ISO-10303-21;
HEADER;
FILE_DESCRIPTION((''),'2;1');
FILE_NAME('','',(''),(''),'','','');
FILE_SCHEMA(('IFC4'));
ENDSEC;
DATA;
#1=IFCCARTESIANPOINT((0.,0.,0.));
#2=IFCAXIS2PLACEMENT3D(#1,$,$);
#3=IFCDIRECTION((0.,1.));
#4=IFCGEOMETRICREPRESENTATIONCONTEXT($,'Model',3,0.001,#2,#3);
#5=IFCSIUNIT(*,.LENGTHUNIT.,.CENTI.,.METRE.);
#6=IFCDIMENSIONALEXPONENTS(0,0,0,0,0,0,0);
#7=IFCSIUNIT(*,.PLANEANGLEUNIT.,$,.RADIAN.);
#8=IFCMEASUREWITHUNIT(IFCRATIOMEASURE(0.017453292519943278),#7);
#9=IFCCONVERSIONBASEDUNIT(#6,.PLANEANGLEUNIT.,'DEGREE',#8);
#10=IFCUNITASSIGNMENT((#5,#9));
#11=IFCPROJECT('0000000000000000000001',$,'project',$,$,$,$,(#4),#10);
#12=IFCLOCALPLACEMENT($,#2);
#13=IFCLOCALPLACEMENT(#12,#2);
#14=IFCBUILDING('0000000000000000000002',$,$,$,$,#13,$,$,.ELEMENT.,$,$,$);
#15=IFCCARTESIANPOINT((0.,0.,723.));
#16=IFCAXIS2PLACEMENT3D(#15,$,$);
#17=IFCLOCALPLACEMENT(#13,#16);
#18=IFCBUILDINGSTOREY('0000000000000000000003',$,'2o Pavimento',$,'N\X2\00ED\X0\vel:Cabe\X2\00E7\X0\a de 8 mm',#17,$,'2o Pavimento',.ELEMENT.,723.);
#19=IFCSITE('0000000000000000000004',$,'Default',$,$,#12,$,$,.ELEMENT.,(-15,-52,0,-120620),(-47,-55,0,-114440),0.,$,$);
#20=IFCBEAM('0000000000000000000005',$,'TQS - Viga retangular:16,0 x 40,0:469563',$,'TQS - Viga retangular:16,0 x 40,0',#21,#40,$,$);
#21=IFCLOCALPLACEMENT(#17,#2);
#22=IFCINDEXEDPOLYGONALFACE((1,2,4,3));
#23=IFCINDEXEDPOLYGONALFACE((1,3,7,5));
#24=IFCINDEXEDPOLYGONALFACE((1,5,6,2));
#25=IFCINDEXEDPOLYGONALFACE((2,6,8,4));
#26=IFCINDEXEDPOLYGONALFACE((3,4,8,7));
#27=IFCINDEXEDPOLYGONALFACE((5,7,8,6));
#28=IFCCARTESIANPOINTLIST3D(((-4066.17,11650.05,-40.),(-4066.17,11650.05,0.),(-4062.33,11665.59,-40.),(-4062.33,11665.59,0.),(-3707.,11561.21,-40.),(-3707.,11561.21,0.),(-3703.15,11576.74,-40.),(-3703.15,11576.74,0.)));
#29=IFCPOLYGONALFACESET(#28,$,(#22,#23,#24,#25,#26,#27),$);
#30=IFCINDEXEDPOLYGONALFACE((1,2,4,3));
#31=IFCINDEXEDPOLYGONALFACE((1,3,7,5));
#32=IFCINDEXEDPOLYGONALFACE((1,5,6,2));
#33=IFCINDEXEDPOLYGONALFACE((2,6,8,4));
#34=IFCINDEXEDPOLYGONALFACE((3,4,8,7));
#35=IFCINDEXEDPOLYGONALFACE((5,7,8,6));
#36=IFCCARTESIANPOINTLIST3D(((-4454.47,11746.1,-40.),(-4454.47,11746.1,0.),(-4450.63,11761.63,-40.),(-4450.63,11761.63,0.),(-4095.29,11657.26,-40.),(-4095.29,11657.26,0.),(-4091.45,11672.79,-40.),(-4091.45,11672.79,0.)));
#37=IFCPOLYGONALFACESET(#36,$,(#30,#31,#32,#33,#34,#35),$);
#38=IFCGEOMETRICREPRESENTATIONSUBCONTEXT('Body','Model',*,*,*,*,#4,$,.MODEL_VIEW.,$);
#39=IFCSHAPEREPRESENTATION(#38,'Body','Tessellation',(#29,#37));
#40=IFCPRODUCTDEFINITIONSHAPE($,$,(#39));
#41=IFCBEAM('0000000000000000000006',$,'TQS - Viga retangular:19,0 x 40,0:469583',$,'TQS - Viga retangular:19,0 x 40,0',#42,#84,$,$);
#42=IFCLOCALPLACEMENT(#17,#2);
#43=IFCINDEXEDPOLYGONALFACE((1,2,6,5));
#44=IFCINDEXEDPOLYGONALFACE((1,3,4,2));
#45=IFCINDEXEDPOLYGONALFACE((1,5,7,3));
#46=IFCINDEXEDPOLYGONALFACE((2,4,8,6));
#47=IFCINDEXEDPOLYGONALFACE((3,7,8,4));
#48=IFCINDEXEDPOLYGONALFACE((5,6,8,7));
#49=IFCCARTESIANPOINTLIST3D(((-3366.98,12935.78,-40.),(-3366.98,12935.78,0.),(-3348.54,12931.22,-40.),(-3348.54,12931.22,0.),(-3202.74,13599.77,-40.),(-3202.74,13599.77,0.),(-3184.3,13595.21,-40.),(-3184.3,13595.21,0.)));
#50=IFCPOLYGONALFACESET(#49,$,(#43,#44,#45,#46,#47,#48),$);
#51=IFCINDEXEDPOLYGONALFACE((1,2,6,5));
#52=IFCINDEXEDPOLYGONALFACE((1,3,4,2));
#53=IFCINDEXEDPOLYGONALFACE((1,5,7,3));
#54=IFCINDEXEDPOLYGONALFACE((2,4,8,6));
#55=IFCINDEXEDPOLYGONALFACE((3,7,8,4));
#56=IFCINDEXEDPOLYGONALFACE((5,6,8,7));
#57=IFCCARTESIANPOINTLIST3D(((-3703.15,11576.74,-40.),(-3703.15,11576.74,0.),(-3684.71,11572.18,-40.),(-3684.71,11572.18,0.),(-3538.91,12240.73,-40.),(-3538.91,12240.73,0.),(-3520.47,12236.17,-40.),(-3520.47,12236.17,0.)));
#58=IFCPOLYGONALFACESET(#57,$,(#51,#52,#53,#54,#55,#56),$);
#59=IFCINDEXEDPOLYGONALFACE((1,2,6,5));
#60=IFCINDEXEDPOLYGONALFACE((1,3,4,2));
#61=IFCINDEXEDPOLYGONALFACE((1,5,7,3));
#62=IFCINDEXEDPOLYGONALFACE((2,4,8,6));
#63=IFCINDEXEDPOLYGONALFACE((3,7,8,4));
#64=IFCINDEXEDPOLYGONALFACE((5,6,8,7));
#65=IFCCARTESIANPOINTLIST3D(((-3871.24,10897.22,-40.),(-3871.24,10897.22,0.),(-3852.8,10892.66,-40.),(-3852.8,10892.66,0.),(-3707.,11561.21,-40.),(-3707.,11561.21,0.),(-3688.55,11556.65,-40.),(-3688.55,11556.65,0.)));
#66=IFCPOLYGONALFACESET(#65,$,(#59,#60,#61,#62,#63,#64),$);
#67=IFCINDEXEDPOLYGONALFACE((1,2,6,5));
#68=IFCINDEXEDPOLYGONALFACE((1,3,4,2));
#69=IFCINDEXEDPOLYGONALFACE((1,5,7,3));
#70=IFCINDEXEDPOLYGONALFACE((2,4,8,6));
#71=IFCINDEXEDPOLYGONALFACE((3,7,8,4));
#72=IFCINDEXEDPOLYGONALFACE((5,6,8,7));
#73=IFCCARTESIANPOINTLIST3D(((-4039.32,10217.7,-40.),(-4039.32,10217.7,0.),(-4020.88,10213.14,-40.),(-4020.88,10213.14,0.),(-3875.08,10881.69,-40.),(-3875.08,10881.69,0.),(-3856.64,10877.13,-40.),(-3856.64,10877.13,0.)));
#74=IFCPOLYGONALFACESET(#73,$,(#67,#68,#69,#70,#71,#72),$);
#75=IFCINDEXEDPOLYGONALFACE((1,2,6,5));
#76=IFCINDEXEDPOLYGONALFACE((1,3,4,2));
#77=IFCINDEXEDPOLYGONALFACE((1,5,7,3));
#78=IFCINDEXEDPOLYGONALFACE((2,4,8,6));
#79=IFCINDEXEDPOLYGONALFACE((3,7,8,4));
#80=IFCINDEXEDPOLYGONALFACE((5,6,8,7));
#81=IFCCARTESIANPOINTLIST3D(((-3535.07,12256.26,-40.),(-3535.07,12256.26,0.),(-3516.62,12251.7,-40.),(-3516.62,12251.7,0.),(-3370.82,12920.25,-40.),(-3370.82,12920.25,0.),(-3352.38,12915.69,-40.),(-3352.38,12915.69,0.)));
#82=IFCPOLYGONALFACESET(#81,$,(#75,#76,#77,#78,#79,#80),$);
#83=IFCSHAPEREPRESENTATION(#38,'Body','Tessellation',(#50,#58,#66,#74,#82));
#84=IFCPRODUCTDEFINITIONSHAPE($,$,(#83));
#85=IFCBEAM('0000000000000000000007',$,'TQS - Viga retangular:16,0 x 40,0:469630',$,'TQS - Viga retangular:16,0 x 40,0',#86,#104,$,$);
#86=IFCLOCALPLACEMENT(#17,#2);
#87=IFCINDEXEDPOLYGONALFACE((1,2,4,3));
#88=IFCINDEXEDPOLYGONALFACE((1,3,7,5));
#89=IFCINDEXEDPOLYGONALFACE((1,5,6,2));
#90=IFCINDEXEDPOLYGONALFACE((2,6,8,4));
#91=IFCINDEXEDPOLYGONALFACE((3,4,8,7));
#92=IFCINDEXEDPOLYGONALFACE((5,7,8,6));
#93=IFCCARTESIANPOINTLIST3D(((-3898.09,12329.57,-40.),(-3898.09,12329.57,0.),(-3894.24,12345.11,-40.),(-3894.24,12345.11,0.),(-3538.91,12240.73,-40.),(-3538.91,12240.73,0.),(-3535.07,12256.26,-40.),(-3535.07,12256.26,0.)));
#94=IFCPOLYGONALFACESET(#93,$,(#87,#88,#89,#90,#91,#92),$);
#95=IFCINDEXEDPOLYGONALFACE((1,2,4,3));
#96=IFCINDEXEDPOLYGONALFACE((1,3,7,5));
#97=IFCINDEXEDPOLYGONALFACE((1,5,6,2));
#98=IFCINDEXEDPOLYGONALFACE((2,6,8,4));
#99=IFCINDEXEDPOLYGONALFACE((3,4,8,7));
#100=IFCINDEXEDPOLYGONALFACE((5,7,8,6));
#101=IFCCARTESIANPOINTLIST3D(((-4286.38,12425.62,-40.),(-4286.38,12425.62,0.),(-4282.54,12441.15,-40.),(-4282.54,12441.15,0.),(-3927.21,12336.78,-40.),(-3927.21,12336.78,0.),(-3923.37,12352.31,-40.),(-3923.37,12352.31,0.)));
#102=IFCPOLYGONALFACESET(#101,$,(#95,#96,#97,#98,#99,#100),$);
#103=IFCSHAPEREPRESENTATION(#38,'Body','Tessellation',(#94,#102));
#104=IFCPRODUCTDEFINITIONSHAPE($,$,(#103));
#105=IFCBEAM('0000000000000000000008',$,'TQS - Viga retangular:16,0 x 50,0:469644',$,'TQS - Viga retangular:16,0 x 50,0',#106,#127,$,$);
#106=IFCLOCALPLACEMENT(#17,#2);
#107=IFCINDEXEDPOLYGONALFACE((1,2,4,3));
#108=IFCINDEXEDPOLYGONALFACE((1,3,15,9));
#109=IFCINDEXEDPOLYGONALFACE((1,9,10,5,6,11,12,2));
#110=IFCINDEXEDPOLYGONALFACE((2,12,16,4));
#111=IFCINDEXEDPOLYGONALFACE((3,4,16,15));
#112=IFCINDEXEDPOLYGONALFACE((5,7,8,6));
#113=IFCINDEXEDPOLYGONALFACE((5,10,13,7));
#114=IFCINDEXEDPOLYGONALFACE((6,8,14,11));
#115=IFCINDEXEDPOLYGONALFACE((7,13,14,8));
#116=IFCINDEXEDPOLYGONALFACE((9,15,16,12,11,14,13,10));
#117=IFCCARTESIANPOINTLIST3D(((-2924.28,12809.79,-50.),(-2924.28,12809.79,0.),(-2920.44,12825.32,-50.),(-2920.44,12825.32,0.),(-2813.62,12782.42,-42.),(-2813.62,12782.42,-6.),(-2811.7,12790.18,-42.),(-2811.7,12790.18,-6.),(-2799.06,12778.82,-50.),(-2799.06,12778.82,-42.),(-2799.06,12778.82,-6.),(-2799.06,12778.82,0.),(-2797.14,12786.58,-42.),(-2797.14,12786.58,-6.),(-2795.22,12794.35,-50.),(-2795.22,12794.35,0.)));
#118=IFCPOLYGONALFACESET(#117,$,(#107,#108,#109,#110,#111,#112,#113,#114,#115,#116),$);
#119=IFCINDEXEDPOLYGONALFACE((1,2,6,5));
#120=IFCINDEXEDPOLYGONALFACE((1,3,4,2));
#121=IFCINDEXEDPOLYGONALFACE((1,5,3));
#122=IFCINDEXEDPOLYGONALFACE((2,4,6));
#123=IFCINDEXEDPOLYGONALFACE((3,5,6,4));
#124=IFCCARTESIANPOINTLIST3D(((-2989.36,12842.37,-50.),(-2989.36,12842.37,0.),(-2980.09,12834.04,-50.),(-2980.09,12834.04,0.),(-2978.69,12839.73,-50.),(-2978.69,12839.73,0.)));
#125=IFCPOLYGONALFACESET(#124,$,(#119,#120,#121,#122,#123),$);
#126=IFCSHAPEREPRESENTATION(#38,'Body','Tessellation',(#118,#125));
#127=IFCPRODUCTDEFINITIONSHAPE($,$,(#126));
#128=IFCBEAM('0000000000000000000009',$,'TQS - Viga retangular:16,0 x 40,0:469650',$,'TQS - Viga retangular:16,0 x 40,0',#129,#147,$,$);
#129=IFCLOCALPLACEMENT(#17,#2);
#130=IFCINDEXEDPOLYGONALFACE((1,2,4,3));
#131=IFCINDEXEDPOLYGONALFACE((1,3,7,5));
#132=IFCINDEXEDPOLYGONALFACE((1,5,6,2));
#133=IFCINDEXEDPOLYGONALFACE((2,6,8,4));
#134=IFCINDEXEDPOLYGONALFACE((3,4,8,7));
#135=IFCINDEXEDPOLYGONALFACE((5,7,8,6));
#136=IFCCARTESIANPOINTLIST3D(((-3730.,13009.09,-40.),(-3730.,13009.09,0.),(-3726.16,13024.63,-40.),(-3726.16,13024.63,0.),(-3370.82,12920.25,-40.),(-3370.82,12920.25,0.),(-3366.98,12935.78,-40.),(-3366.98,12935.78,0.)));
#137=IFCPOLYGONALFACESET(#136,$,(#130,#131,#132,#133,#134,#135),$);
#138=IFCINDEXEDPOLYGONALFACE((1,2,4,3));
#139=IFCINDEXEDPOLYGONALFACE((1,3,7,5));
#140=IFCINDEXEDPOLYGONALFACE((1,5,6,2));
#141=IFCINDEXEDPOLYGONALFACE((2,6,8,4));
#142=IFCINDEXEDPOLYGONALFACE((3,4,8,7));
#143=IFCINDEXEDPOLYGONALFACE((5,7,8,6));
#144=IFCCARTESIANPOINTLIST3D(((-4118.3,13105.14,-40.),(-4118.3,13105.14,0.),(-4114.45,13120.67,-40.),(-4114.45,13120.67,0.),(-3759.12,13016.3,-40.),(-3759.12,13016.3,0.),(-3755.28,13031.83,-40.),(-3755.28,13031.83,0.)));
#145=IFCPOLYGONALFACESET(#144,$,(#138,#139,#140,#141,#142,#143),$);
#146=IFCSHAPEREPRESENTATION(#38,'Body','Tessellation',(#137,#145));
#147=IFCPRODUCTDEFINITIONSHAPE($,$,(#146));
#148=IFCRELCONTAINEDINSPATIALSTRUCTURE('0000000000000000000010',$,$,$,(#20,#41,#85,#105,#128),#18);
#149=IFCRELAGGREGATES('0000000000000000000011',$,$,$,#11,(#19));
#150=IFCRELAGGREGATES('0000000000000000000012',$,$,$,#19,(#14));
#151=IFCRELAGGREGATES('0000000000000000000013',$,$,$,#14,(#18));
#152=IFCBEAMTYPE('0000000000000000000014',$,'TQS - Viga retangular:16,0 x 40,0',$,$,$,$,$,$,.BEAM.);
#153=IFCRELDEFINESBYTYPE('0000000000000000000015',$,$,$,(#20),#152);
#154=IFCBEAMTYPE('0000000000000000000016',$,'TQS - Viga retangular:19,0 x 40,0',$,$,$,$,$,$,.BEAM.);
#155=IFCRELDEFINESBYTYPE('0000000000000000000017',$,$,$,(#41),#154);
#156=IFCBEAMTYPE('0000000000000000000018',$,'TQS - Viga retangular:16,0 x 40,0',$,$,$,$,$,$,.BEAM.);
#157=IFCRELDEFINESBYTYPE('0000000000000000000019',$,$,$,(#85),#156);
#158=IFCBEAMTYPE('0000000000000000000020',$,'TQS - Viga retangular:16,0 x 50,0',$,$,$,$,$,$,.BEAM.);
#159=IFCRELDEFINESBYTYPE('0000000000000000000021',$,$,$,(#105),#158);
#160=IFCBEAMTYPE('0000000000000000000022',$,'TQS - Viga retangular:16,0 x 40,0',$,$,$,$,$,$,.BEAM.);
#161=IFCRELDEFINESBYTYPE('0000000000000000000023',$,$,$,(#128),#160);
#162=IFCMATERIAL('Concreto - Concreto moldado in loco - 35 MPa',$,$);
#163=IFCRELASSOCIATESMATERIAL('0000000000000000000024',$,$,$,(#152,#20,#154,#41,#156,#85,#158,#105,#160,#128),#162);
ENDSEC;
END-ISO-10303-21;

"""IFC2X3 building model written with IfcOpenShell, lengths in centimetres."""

from ifc_helpers import new_model, entity, si_unit, converted_unit, direction, frame, frame_2d, origin, origin_2d_with_axis, place, context, subcontext, project, spatial, polyline, rectangle, extrude, boolean, clip, halfspace, bounded_halfspace, source, transform, mapped, material, type_object, type_shapes, element, save


model = new_model("IFC2X3")

# Units and contexts
model_context = context("Model", 3, precision=0.001, world=origin(), true_north=direction((0.0, 1.0)))
body_context = subcontext(model_context, "Body", "Model", "MODEL_VIEW")
ifc_project = project(units=[si_unit("LENGTHUNIT", "METRE", prefix="CENTI"), converted_unit("PLANEANGLEUNIT", "DEGREE", entity("IfcRatioMeasure", 0.017453292519943278), si_unit("PLANEANGLEUNIT", "RADIAN"), dimensions=[0, 0, 0, 0, 0, 0, 0])], contexts=[model_context])

# Site, building, storey
site_placement = place(None, origin())
site = spatial("IfcSite", under=ifc_project, at=site_placement, Name="Default", CompositionType="ELEMENT", RefLatitude=(-15, -52, 0, -120620), RefLongitude=(-47, -55, 0, -114440), RefElevation=0.0)
building_placement = place(site_placement, origin())
building = spatial("IfcBuilding", under=site, at=building_placement, CompositionType="ELEMENT")
storey_placement = place(building_placement, frame((0.0, 0.0, 723.0)))
storey = spatial("IfcBuildingStorey", under=building, at=storey_placement, Name="2o Pavimento", ObjectType="Nível:Cabeça de 8 mm", LongName="2o Pavimento", CompositionType="ELEMENT", Elevation=723.0)

# Beams
ifc_material = material(Name="Concreto - Concreto moldado in loco - 35 MPa")
beam_type_1 = type_object("IfcBeamType", Name="TQS - Viga retangular:16,0 x 40,0", PredefinedType="BEAM", material=ifc_material)
shared_shape_1 = source(origin(), body_context, "Body", "SweptSolid", [
    extrude(rectangle(XDim=40.0, YDim=16.0, at=frame_2d((0.0, 0.0), x_axis=(1.0, 0.0))), frame((-3705.07, 11568.97, 703.0), z_axis=(-0.970743, 0.240122, 0.0), x_axis=(0.0, 0.0, 1.0)), (0.0, 0.0, 1.0), 370.0),
    extrude(rectangle(XDim=40.0, YDim=16.0, at=frame_2d((0.0, 0.0), x_axis=(1.0, 0.0))), frame((-4093.37, 11665.02, 703.0), z_axis=(-0.970743, 0.240122, 0.0), x_axis=(0.0, 0.0, 1.0)), (0.0, 0.0, 1.0), 370.0),
])
type_shapes(beam_type_1, [shared_shape_1])
beam_1_placement = place(storey_placement, frame((0.0, 0.0, -723.0)))
element("IfcBeam", 1, at=beam_1_placement, inside=storey, type_object=beam_type_1, material=ifc_material, Name="TQS - Viga retangular:16,0 x 40,0:469563", ObjectType="TQS - Viga retangular:16,0 x 40,0", context=body_context, shape_type="MappedRepresentation", body=[
    mapped(shared_shape_1, transform((0.0, 0.0, 0.0), scale=1.0)),
])
beam_type_2 = type_object("IfcBeamType", Name="TQS - Viga retangular:19,0 x 40,0", PredefinedType="BEAM", material=ifc_material)
shared_shape_2 = source(origin(), body_context, "Body", "SweptSolid", [
    extrude(rectangle(XDim=40.0, YDim=19.0, at=frame_2d((0.0, 0.0), x_axis=(1.0, 0.0))), frame((-3357.76, 12933.5, 703.0), z_axis=(0.240122, 0.970743, 0.0), x_axis=(0.0, 0.0, 1.0)), (0.0, 0.0, 1.0), 684.0),
    extrude(rectangle(XDim=40.0, YDim=19.0, at=frame_2d((0.0, 0.0), x_axis=(1.0, 0.0))), frame((-3693.93, 11574.46, 703.0), z_axis=(0.240122, 0.970743, 0.0), x_axis=(0.0, 0.0, 1.0)), (0.0, 0.0, 1.0), 684.0),
    extrude(rectangle(XDim=40.0, YDim=19.0, at=frame_2d((0.0, 0.0), x_axis=(1.0, 0.0))), frame((-3862.02, 10894.94, 703.0), z_axis=(0.240122, 0.970743, 0.0), x_axis=(0.0, 0.0, 1.0)), (0.0, 0.0, 1.0), 684.0),
    extrude(rectangle(XDim=40.0, YDim=19.0, at=origin_2d_with_axis()), frame((-4030.1, 10215.42, 703.0), z_axis=(0.240122, 0.970743, 0.0), x_axis=(0.0, 0.0, 1.0)), (0.0, 0.0, 1.0), 684.0),
    extrude(rectangle(XDim=40.0, YDim=19.0, at=frame_2d((0.0, 0.0), x_axis=(1.0, 0.0))), frame((-3525.85, 12253.98, 703.0), z_axis=(0.240122, 0.970743, 0.0), x_axis=(0.0, 0.0, 1.0)), (0.0, 0.0, 1.0), 684.0),
])
type_shapes(beam_type_2, [shared_shape_2])
beam_2_placement = place(storey_placement, frame((0.0, 0.0, -723.0)))
element("IfcBeam", 2, at=beam_2_placement, inside=storey, type_object=beam_type_2, material=ifc_material, Name="TQS - Viga retangular:19,0 x 40,0:469583", ObjectType="TQS - Viga retangular:19,0 x 40,0", context=body_context, shape_type="MappedRepresentation", body=[
    mapped(shared_shape_2, transform((0.0, 0.0, 0.0), scale=1.0)),
])
beam_type_3 = type_object("IfcBeamType", Name="TQS - Viga retangular:16,0 x 40,0", PredefinedType="BEAM", material=ifc_material)
shared_shape_3 = source(origin(), body_context, "Body", "SweptSolid", [
    extrude(rectangle(XDim=40.0, YDim=16.0, at=frame_2d((0.0, 0.0), x_axis=(1.0, 0.0))), frame((-3536.99, 12248.49, 703.0), z_axis=(-0.970743, 0.240122, 0.0), x_axis=(0.0, 0.0, 1.0)), (0.0, 0.0, 1.0), 370.0),
    extrude(rectangle(XDim=40.0, YDim=16.0, at=origin_2d_with_axis()), frame((-3925.29, 12344.54, 703.0), z_axis=(-0.970743, 0.240122, 0.0), x_axis=(0.0, 0.0, 1.0)), (0.0, 0.0, 1.0), 370.0),
])
type_shapes(beam_type_3, [shared_shape_3])
beam_3_placement = place(storey_placement, frame((0.0, 0.0, -723.0)))
element("IfcBeam", 3, at=beam_3_placement, inside=storey, type_object=beam_type_3, material=ifc_material, Name="TQS - Viga retangular:16,0 x 40,0:469630", ObjectType="TQS - Viga retangular:16,0 x 40,0", context=body_context, shape_type="MappedRepresentation", body=[
    mapped(shared_shape_3, transform((0.0, 0.0, 0.0), scale=1.0)),
])
beam_type_4 = type_object("IfcBeamType", Name="TQS - Viga retangular:16,0 x 50,0", PredefinedType="BEAM", material=ifc_material)
shared_shape_4 = source(origin(), body_context, "Body", "SweptSolid", [
    boolean("DIFFERENCE", clip(extrude(rectangle(XDim=50.0, YDim=16.0, at=frame_2d((0.0, 0.0), x_axis=(0.0, 1.0))), frame((-2797.14, 12786.58, 698.0), z_axis=(-0.970743, 0.240122, 0.0), x_axis=(0.240122, 0.970743, 0.0)), (0.0, 0.0, 1.0), 129.0), bounded_halfspace(frame((-2811.7, 12790.18, 681.0), z_axis=(0.970743, -0.240122, 0.0), x_axis=(-0.240122, -0.970743, 0.0)), False, frame((-2797.14, 12786.58, 698.0), z_axis=(-0.970743, 0.240122, 0.0), x_axis=(0.240122, 0.970743, 0.0)), polyline([(0.0, 17.0), (0.0, -19.0), (-8.0, -19.0), (-8.0, -9.0), (-8.0, 17.0), (0.0, 17.0)]))), extrude(rectangle(XDim=36.0, YDim=8.0, at=frame_2d((0.0, 0.0), x_axis=(0.0, 1.0))), frame((-2798.1, 12782.7, 699.0), z_axis=(0.970743, -0.240122, 0.0), x_axis=(0.240122, 0.970743, 0.0)), (0.0, 0.0, -1.0), 15.0)),
    clip(extrude(rectangle(XDim=50.0, YDim=5.87, at=frame_2d((0.0, 0.0), x_axis=(0.0, 1.0))), frame((-2979.39, 12836.88, 698.0), z_axis=(-0.970743, 0.240122, 0.0), x_axis=(0.240122, 0.970743, 0.0)), (0.0, 0.0, 1.0), 11.0), halfspace(frame((-2964.08, 12819.64, 723.0), z_axis=(-0.668693, -0.743539, 0.0), x_axis=(0.743539, -0.668693, 0.0)), False)),
])
type_shapes(beam_type_4, [shared_shape_4])
beam_4_placement = place(storey_placement, frame((0.0, 0.0, -723.0)))
element("IfcBeam", 4, at=beam_4_placement, inside=storey, type_object=beam_type_4, material=ifc_material, Name="TQS - Viga retangular:16,0 x 50,0:469644", ObjectType="TQS - Viga retangular:16,0 x 50,0", context=body_context, shape_type="MappedRepresentation", body=[
    mapped(shared_shape_4, transform((0.0, 0.0, 0.0), scale=1.0)),
])
beam_type_5 = type_object("IfcBeamType", Name="TQS - Viga retangular:16,0 x 40,0", PredefinedType="BEAM", material=ifc_material)
shared_shape_5 = source(origin(), body_context, "Body", "SweptSolid", [
    extrude(rectangle(XDim=40.0, YDim=16.0, at=frame_2d((0.0, 0.0), x_axis=(1.0, 0.0))), frame((-3368.9, 12928.01, 703.0), z_axis=(-0.970743, 0.240122, 0.0), x_axis=(0.0, 0.0, 1.0)), (0.0, 0.0, 1.0), 370.0),
    extrude(rectangle(XDim=40.0, YDim=16.0, at=frame_2d((0.0, 0.0), x_axis=(1.0, 0.0))), frame((-3757.2, 13024.06, 703.0), z_axis=(-0.970743, 0.240122, 0.0), x_axis=(0.0, 0.0, 1.0)), (0.0, 0.0, 1.0), 370.0),
])
type_shapes(beam_type_5, [shared_shape_5])
beam_5_placement = place(storey_placement, frame((0.0, 0.0, -723.0)))
element("IfcBeam", 5, at=beam_5_placement, inside=storey, type_object=beam_type_5, material=ifc_material, Name="TQS - Viga retangular:16,0 x 40,0:469650", ObjectType="TQS - Viga retangular:16,0 x 40,0", context=body_context, shape_type="MappedRepresentation", body=[
    mapped(shared_shape_5, transform((0.0, 0.0, 0.0), scale=1.0)),
])

save(model, "model.ifc")
